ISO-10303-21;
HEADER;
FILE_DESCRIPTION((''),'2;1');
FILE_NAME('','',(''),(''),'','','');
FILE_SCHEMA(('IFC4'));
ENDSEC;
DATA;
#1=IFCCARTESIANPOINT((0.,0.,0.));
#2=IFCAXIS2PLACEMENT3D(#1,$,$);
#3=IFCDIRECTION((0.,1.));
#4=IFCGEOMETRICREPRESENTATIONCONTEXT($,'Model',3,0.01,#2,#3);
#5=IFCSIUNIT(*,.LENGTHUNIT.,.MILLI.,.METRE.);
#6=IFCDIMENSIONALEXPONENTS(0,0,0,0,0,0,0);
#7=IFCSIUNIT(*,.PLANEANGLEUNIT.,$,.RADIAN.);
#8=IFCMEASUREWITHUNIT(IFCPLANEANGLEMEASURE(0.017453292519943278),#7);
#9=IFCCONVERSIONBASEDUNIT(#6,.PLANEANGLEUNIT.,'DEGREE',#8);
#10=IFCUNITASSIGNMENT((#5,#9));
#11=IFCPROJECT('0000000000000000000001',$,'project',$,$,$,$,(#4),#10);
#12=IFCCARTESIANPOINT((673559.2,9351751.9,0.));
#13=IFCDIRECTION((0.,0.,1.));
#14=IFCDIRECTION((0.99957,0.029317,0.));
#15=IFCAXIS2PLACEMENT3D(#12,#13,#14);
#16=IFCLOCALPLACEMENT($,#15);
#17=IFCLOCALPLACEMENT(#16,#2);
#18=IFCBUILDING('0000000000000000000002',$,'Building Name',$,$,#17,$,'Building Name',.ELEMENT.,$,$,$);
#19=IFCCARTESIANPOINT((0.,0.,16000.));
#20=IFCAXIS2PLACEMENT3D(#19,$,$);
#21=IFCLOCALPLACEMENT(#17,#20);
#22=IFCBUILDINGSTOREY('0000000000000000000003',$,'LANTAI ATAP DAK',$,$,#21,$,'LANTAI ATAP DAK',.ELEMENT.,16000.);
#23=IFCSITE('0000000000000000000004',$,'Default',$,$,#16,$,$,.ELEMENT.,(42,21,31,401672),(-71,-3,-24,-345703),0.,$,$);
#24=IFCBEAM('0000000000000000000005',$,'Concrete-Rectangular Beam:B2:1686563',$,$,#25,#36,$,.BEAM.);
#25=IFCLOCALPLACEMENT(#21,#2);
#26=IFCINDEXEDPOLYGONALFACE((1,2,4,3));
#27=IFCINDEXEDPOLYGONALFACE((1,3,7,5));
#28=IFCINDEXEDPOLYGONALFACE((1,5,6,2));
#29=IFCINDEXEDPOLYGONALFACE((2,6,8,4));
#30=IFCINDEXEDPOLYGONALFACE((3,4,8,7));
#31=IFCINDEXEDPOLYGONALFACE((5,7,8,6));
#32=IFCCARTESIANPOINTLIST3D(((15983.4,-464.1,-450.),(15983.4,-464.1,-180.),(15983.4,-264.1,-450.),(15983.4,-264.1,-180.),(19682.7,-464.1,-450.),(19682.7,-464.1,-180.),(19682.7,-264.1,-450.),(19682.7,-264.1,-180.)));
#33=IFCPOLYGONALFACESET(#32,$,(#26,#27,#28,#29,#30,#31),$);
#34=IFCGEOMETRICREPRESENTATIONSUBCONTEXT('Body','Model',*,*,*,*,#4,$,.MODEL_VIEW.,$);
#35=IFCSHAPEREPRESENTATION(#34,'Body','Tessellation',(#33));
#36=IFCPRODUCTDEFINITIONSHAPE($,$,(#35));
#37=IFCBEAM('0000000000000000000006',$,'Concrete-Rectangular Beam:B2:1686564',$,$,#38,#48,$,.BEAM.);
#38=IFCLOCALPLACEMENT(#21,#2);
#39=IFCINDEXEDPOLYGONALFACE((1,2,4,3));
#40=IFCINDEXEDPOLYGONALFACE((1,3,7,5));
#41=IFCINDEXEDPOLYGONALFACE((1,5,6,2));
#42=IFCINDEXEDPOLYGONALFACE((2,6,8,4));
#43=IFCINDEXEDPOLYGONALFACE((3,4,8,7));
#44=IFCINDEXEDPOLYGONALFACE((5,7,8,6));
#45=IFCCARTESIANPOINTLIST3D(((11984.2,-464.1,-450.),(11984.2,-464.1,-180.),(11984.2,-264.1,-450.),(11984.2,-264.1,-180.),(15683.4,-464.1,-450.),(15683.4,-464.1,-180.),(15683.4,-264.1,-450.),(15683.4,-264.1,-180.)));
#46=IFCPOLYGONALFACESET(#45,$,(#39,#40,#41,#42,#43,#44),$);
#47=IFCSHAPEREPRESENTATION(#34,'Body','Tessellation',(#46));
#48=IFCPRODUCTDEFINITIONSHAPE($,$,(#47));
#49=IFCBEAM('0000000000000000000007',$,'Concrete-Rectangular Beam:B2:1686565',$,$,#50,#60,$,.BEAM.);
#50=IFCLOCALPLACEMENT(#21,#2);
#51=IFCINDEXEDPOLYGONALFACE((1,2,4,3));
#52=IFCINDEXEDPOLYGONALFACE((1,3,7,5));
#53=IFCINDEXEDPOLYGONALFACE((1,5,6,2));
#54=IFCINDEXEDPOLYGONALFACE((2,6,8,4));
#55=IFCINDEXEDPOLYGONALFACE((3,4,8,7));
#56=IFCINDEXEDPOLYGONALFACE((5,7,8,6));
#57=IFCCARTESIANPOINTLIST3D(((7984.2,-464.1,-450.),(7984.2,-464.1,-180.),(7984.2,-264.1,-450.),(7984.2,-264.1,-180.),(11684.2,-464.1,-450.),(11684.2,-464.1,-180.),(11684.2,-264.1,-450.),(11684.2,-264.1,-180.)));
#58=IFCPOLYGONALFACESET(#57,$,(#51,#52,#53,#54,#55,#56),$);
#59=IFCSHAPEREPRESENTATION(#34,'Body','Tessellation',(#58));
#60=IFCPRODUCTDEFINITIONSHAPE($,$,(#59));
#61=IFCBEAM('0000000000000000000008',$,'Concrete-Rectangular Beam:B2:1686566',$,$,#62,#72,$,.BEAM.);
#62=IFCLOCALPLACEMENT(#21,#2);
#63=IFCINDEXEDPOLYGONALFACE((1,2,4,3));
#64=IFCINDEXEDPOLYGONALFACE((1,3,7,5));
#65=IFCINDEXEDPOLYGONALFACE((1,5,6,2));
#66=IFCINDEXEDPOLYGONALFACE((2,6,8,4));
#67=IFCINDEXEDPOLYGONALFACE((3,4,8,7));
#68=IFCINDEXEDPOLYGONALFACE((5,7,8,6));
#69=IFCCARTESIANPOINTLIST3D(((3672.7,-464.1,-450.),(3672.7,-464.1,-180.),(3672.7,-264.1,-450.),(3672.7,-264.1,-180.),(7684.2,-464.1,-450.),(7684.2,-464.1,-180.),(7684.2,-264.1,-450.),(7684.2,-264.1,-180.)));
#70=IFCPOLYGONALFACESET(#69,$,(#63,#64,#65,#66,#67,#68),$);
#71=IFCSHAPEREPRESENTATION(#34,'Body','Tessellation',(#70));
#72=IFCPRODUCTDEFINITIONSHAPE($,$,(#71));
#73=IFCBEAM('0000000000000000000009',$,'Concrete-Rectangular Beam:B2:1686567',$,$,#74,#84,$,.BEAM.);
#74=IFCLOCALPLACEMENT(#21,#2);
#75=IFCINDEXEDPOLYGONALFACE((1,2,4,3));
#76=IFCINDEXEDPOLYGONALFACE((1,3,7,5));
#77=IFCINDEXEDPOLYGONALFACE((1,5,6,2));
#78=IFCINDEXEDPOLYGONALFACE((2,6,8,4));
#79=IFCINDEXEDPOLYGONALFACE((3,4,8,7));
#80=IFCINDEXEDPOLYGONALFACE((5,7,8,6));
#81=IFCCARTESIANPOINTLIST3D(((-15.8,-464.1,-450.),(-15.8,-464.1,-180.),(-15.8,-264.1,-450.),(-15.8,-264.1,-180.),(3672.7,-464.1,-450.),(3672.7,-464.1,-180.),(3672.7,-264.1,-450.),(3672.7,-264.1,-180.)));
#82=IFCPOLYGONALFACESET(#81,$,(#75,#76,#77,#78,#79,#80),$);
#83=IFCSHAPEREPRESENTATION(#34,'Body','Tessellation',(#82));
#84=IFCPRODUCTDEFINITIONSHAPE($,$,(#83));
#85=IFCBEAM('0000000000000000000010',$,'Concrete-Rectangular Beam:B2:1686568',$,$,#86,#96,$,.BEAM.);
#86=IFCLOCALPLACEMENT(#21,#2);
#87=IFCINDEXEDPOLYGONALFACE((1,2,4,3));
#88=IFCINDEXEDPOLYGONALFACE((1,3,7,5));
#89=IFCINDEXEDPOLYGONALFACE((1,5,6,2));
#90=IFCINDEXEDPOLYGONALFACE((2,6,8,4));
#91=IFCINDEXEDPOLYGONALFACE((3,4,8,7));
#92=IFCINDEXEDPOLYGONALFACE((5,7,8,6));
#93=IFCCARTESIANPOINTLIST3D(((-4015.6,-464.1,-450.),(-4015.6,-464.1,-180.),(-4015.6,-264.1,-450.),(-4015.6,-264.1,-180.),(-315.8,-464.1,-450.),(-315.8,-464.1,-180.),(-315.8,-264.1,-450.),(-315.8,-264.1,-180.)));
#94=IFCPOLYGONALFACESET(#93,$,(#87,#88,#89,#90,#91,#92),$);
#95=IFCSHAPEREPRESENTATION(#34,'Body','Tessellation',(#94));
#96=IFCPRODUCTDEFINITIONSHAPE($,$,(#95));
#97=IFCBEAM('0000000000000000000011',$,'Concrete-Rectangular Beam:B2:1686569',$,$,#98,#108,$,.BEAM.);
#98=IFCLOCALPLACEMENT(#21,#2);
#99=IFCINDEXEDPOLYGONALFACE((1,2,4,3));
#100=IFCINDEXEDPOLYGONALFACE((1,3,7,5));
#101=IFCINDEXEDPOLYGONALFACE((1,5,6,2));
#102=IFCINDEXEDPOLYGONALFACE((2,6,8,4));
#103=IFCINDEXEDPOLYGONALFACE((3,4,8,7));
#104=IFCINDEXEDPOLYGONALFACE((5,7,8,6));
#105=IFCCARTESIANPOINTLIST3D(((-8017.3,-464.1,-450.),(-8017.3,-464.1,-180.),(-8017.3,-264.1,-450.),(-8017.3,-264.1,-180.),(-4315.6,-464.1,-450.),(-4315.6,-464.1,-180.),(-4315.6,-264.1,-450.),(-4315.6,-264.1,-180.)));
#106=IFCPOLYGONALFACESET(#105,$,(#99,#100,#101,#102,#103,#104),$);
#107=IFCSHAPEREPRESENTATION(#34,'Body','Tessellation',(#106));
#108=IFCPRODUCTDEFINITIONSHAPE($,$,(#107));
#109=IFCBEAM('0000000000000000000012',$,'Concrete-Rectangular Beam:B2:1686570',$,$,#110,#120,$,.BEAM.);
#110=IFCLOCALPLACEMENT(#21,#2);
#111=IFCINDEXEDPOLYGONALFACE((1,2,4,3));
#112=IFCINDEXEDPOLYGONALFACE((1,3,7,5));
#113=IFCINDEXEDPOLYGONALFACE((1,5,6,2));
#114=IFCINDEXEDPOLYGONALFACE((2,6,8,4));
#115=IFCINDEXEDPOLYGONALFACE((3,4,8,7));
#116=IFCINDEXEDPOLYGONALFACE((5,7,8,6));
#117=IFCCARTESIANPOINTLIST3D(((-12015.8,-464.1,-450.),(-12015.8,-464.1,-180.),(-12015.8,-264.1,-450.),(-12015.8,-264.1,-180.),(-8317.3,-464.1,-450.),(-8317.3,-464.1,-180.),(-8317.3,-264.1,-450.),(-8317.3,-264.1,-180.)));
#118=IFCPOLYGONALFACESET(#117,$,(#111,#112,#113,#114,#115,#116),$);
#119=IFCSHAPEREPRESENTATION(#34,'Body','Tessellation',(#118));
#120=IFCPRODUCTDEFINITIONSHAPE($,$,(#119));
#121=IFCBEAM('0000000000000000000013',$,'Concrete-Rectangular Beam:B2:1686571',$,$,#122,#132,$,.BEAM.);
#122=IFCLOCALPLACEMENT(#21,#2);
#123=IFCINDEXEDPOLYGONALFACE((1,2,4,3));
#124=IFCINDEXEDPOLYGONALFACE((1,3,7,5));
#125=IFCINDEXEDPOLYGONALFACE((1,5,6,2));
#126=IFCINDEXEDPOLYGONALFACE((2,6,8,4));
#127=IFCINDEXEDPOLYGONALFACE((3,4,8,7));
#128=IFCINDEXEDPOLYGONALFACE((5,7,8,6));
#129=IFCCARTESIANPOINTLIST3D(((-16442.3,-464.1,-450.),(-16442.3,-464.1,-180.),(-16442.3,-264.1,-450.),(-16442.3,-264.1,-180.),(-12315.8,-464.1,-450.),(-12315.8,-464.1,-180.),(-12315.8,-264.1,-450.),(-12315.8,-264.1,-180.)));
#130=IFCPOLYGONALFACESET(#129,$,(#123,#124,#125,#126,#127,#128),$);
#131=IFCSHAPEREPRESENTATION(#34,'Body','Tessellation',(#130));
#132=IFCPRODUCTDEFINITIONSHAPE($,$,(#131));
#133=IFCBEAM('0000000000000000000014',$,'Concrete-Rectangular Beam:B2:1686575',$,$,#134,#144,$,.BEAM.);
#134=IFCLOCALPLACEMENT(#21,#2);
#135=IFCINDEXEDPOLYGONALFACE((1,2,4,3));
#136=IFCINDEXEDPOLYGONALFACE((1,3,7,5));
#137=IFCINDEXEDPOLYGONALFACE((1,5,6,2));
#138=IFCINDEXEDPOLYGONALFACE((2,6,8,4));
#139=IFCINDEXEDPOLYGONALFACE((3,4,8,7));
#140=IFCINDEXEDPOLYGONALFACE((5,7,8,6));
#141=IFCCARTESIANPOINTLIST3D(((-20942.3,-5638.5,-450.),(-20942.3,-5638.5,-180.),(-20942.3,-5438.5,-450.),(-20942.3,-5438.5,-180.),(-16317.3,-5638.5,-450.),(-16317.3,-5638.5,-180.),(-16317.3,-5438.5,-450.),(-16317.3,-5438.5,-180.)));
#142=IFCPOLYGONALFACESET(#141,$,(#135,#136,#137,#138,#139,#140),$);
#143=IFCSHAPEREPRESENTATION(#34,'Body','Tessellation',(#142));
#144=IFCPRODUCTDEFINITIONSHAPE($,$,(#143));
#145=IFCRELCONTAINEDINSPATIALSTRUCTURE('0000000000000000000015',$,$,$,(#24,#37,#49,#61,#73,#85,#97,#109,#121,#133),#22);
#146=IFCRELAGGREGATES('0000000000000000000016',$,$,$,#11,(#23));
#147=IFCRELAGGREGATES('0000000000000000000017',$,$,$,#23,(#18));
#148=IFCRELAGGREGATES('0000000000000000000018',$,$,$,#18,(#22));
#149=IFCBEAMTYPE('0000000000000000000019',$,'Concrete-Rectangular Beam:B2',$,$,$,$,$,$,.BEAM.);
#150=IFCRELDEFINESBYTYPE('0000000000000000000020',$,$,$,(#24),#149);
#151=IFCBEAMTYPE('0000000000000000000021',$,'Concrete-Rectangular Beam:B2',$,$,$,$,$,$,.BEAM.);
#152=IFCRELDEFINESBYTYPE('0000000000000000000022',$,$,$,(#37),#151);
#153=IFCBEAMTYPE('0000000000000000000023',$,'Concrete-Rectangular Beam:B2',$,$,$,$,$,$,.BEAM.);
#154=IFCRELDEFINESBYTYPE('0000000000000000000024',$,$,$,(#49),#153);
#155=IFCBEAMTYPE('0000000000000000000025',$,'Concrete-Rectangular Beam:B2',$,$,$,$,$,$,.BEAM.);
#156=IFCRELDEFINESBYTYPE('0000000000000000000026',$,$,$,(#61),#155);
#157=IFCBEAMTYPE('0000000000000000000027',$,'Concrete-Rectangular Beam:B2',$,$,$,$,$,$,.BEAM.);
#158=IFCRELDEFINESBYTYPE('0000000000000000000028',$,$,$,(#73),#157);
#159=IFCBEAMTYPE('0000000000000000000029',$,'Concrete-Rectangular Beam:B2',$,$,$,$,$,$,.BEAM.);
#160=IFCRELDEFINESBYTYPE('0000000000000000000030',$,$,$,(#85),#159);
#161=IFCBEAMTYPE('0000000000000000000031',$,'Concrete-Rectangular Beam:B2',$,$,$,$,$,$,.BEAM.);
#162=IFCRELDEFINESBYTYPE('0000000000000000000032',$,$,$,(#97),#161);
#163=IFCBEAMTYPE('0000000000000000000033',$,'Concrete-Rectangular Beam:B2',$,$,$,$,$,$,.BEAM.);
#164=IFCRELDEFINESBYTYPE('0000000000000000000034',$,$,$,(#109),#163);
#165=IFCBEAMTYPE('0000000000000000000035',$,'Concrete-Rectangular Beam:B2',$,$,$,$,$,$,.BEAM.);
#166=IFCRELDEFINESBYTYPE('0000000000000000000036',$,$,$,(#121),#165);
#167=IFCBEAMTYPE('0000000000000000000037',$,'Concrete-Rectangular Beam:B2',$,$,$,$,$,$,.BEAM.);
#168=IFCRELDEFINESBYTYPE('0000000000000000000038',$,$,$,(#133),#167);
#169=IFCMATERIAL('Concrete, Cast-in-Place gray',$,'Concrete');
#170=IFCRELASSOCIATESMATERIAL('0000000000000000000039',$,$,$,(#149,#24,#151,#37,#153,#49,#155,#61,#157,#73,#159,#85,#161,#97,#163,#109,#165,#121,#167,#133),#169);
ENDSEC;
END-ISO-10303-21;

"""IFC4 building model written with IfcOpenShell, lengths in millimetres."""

from ifc_helpers import new_model, entity, si_unit, converted_unit, direction, frame, origin, place, context, subcontext, project, spatial, indexed_curve, outline, extrude, source, transform, mapped, material, type_object, type_shapes, element, save


model = new_model("IFC4")

# Units and contexts
model_context = context("Model", 3, precision=0.01, world=origin(), true_north=direction((0.0, 1.0)))
body_context = subcontext(model_context, "Body", "Model", "MODEL_VIEW")
ifc_project = project(units=[si_unit("LENGTHUNIT", "METRE", prefix="MILLI"), converted_unit("PLANEANGLEUNIT", "DEGREE", entity("IfcPlaneAngleMeasure", 0.017453292519943278), si_unit("PLANEANGLEUNIT", "RADIAN"), dimensions=[0, 0, 0, 0, 0, 0, 0])], contexts=[model_context])

# Site, building, storey
site_placement = place(None, frame((673559.2, 9351751.9, 0.0), z_axis=(0.0, 0.0, 1.0), x_axis=(0.99957, 0.029317, 0.0)))
site = spatial("IfcSite", under=ifc_project, at=site_placement, Name="Default", CompositionType="ELEMENT", RefLatitude=(42, 21, 31, 401672), RefLongitude=(-71, -3, -24, -345703), RefElevation=0.0)
building_placement = place(site_placement, origin())
building = spatial("IfcBuilding", under=site, at=building_placement, Name="Building Name", LongName="Building Name", CompositionType="ELEMENT")
storey_placement = place(building_placement, frame((0.0, 0.0, 16000.0)))
storey = spatial("IfcBuildingStorey", under=building, at=storey_placement, Name="LANTAI ATAP DAK", LongName="LANTAI ATAP DAK", CompositionType="ELEMENT", Elevation=16000.0)

# Beams
ifc_material = material(Name="Concrete, Cast-in-Place gray", Category="Concrete")
beam_type_1 = type_object("IfcBeamType", Name="Concrete-Rectangular Beam:B2", PredefinedType="BEAM", material=ifc_material)
shared_shape_1 = source(origin(), body_context, "Body", "SweptSolid", [
    extrude(outline(indexed_curve([(-135.0, -100.0), (135.0, -100.0), (135.0, 100.0), (-135.0, 100.0), (-135.0, -100.0)], self_intersect=False)), frame((19682.7, -364.1, 15685.0), z_axis=(-1.0, 0.0, 0.0), x_axis=(0.0, 0.0, -1.0)), (0.0, 0.0, 1.0), 3699.3),
])
type_shapes(beam_type_1, [shared_shape_1])
beam_1_placement = place(storey_placement, frame((0.0, 0.0, -16000.0)))
element("IfcBeam", 1, at=beam_1_placement, inside=storey, type_object=beam_type_1, material=ifc_material, Name="Concrete-Rectangular Beam:B2:1686563", PredefinedType="BEAM", context=body_context, shape_type="MappedRepresentation", body=[
    mapped(shared_shape_1, transform((0.0, 0.0, 0.0), scale=1.0)),
])
beam_type_2 = type_object("IfcBeamType", Name="Concrete-Rectangular Beam:B2", PredefinedType="BEAM", material=ifc_material)
shared_shape_2 = source(origin(), body_context, "Body", "SweptSolid", [
    extrude(outline(indexed_curve([(-135.0, -100.0), (135.0, -100.0), (135.0, 100.0), (-135.0, 100.0), (-135.0, -100.0)], self_intersect=False)), frame((11984.2, -364.1, 15685.0), z_axis=(1.0, 0.0, 0.0), x_axis=(0.0, 0.0, -1.0)), (0.0, 0.0, 1.0), 3699.3),
])
type_shapes(beam_type_2, [shared_shape_2])
beam_2_placement = place(storey_placement, frame((0.0, 0.0, -16000.0)))
element("IfcBeam", 2, at=beam_2_placement, inside=storey, type_object=beam_type_2, material=ifc_material, Name="Concrete-Rectangular Beam:B2:1686564", PredefinedType="BEAM", context=body_context, shape_type="MappedRepresentation", body=[
    mapped(shared_shape_2, transform((0.0, 0.0, 0.0), scale=1.0)),
])
beam_type_3 = type_object("IfcBeamType", Name="Concrete-Rectangular Beam:B2", PredefinedType="BEAM", material=ifc_material)
shared_shape_3 = source(origin(), body_context, "Body", "SweptSolid", [
    extrude(outline(indexed_curve([(-135.0, -100.0), (135.0, -100.0), (135.0, 100.0), (-135.0, 100.0), (-135.0, -100.0)], self_intersect=False)), frame((11684.2, -364.1, 15685.0), z_axis=(-1.0, 0.0, 0.0), x_axis=(0.0, 0.0, -1.0)), (0.0, 0.0, 1.0), 3700.0),
])
type_shapes(beam_type_3, [shared_shape_3])
beam_3_placement = place(storey_placement, frame((0.0, 0.0, -16000.0)))
element("IfcBeam", 3, at=beam_3_placement, inside=storey, type_object=beam_type_3, material=ifc_material, Name="Concrete-Rectangular Beam:B2:1686565", PredefinedType="BEAM", context=body_context, shape_type="MappedRepresentation", body=[
    mapped(shared_shape_3, transform((0.0, 0.0, 0.0), scale=1.0)),
])
beam_type_4 = type_object("IfcBeamType", Name="Concrete-Rectangular Beam:B2", PredefinedType="BEAM", material=ifc_material)
shared_shape_4 = source(origin(), body_context, "Body", "SweptSolid", [
    extrude(outline(indexed_curve([(-135.0, -100.0), (135.0, -100.0), (135.0, 100.0), (-135.0, 100.0), (-135.0, -100.0)], self_intersect=False)), frame((7684.2, -364.1, 15685.0), z_axis=(-1.0, 0.0, 0.0), x_axis=(0.0, 0.0, -1.0)), (0.0, 0.0, 1.0), 4011.4),
])
type_shapes(beam_type_4, [shared_shape_4])
beam_4_placement = place(storey_placement, frame((0.0, 0.0, -16000.0)))
element("IfcBeam", 4, at=beam_4_placement, inside=storey, type_object=beam_type_4, material=ifc_material, Name="Concrete-Rectangular Beam:B2:1686566", PredefinedType="BEAM", context=body_context, shape_type="MappedRepresentation", body=[
    mapped(shared_shape_4, transform((0.0, 0.0, 0.0), scale=1.0)),
])
beam_type_5 = type_object("IfcBeamType", Name="Concrete-Rectangular Beam:B2", PredefinedType="BEAM", material=ifc_material)
shared_shape_5 = source(origin(), body_context, "Body", "SweptSolid", [
    extrude(outline(indexed_curve([(-135.0, -100.0), (135.0, -100.0), (135.0, 100.0), (-135.0, 100.0), (-135.0, -100.0)], self_intersect=False)), frame((3672.7, -364.1, 15685.0), z_axis=(-1.0, 0.0, 0.0), x_axis=(0.0, 0.0, -1.0)), (0.0, 0.0, 1.0), 3688.6),
])
type_shapes(beam_type_5, [shared_shape_5])
beam_5_placement = place(storey_placement, frame((0.0, 0.0, -16000.0)))
element("IfcBeam", 5, at=beam_5_placement, inside=storey, type_object=beam_type_5, material=ifc_material, Name="Concrete-Rectangular Beam:B2:1686567", PredefinedType="BEAM", context=body_context, shape_type="MappedRepresentation", body=[
    mapped(shared_shape_5, transform((0.0, 0.0, 0.0), scale=1.0)),
])
beam_type_6 = type_object("IfcBeamType", Name="Concrete-Rectangular Beam:B2", PredefinedType="BEAM", material=ifc_material)
shared_shape_6 = source(origin(), body_context, "Body", "SweptSolid", [
    extrude(outline(indexed_curve([(-135.0, -100.0), (135.0, -100.0), (135.0, 100.0), (-135.0, 100.0), (-135.0, -100.0)], self_intersect=False)), frame((-315.8, -364.1, 15685.0), z_axis=(-1.0, 0.0, 0.0), x_axis=(0.0, 0.0, -1.0)), (0.0, 0.0, 1.0), 3699.7),
])
type_shapes(beam_type_6, [shared_shape_6])
beam_6_placement = place(storey_placement, frame((0.0, 0.0, -16000.0)))
element("IfcBeam", 6, at=beam_6_placement, inside=storey, type_object=beam_type_6, material=ifc_material, Name="Concrete-Rectangular Beam:B2:1686568", PredefinedType="BEAM", context=body_context, shape_type="MappedRepresentation", body=[
    mapped(shared_shape_6, transform((0.0, 0.0, 0.0), scale=1.0)),
])
beam_type_7 = type_object("IfcBeamType", Name="Concrete-Rectangular Beam:B2", PredefinedType="BEAM", material=ifc_material)
shared_shape_7 = source(origin(), body_context, "Body", "SweptSolid", [
    extrude(outline(indexed_curve([(-135.0, -100.0), (135.0, -100.0), (135.0, 100.0), (-135.0, 100.0), (-135.0, -100.0)], self_intersect=False)), frame((-4315.6, -364.1, 15685.0), z_axis=(-1.0, 0.0, 0.0), x_axis=(0.0, 0.0, -1.0)), (0.0, 0.0, 1.0), 3701.8),
])
type_shapes(beam_type_7, [shared_shape_7])
beam_7_placement = place(storey_placement, frame((0.0, 0.0, -16000.0)))
element("IfcBeam", 7, at=beam_7_placement, inside=storey, type_object=beam_type_7, material=ifc_material, Name="Concrete-Rectangular Beam:B2:1686569", PredefinedType="BEAM", context=body_context, shape_type="MappedRepresentation", body=[
    mapped(shared_shape_7, transform((0.0, 0.0, 0.0), scale=1.0)),
])
beam_type_8 = type_object("IfcBeamType", Name="Concrete-Rectangular Beam:B2", PredefinedType="BEAM", material=ifc_material)
shared_shape_8 = source(origin(), body_context, "Body", "SweptSolid", [
    extrude(outline(indexed_curve([(-135.0, -100.0), (135.0, -100.0), (135.0, 100.0), (-135.0, 100.0), (-135.0, -100.0)], self_intersect=False)), frame((-8317.3, -364.1, 15685.0), z_axis=(-1.0, 0.0, 0.0), x_axis=(0.0, 0.0, -1.0)), (0.0, 0.0, 1.0), 3698.5),
])
type_shapes(beam_type_8, [shared_shape_8])
beam_8_placement = place(storey_placement, frame((0.0, 0.0, -16000.0)))
element("IfcBeam", 8, at=beam_8_placement, inside=storey, type_object=beam_type_8, material=ifc_material, Name="Concrete-Rectangular Beam:B2:1686570", PredefinedType="BEAM", context=body_context, shape_type="MappedRepresentation", body=[
    mapped(shared_shape_8, transform((0.0, 0.0, 0.0), scale=1.0)),
])
beam_type_9 = type_object("IfcBeamType", Name="Concrete-Rectangular Beam:B2", PredefinedType="BEAM", material=ifc_material)
shared_shape_9 = source(origin(), body_context, "Body", "SweptSolid", [
    extrude(outline(indexed_curve([(-135.0, -100.0), (135.0, -100.0), (135.0, 100.0), (-135.0, 100.0), (-135.0, -100.0)], self_intersect=False)), frame((-12315.8, -364.1, 15685.0), z_axis=(-1.0, 0.0, 0.0), x_axis=(0.0, 0.0, -1.0)), (0.0, 0.0, 1.0), 4126.5),
])
type_shapes(beam_type_9, [shared_shape_9])
beam_9_placement = place(storey_placement, frame((0.0, 0.0, -16000.0)))
element("IfcBeam", 9, at=beam_9_placement, inside=storey, type_object=beam_type_9, material=ifc_material, Name="Concrete-Rectangular Beam:B2:1686571", PredefinedType="BEAM", context=body_context, shape_type="MappedRepresentation", body=[
    mapped(shared_shape_9, transform((0.0, 0.0, 0.0), scale=1.0)),
])
beam_type_10 = type_object("IfcBeamType", Name="Concrete-Rectangular Beam:B2", PredefinedType="BEAM", material=ifc_material)
shared_shape_10 = source(origin(), body_context, "Body", "SweptSolid", [
    extrude(outline(indexed_curve([(-135.0, -100.0), (135.0, -100.0), (135.0, 100.0), (-135.0, 100.0), (-135.0, -100.0)], self_intersect=False)), frame((-20942.3, -5538.5, 15685.0), z_axis=(1.0, 0.0, 0.0), x_axis=(0.0, 0.0, -1.0)), (0.0, 0.0, 1.0), 4625.0),
])
type_shapes(beam_type_10, [shared_shape_10])
beam_10_placement = place(storey_placement, frame((0.0, 0.0, -16000.0)))
element("IfcBeam", 10, at=beam_10_placement, inside=storey, type_object=beam_type_10, material=ifc_material, Name="Concrete-Rectangular Beam:B2:1686575", PredefinedType="BEAM", context=body_context, shape_type="MappedRepresentation", body=[
    mapped(shared_shape_10, transform((0.0, 0.0, 0.0), scale=1.0)),
])

save(model, "model.ifc")
